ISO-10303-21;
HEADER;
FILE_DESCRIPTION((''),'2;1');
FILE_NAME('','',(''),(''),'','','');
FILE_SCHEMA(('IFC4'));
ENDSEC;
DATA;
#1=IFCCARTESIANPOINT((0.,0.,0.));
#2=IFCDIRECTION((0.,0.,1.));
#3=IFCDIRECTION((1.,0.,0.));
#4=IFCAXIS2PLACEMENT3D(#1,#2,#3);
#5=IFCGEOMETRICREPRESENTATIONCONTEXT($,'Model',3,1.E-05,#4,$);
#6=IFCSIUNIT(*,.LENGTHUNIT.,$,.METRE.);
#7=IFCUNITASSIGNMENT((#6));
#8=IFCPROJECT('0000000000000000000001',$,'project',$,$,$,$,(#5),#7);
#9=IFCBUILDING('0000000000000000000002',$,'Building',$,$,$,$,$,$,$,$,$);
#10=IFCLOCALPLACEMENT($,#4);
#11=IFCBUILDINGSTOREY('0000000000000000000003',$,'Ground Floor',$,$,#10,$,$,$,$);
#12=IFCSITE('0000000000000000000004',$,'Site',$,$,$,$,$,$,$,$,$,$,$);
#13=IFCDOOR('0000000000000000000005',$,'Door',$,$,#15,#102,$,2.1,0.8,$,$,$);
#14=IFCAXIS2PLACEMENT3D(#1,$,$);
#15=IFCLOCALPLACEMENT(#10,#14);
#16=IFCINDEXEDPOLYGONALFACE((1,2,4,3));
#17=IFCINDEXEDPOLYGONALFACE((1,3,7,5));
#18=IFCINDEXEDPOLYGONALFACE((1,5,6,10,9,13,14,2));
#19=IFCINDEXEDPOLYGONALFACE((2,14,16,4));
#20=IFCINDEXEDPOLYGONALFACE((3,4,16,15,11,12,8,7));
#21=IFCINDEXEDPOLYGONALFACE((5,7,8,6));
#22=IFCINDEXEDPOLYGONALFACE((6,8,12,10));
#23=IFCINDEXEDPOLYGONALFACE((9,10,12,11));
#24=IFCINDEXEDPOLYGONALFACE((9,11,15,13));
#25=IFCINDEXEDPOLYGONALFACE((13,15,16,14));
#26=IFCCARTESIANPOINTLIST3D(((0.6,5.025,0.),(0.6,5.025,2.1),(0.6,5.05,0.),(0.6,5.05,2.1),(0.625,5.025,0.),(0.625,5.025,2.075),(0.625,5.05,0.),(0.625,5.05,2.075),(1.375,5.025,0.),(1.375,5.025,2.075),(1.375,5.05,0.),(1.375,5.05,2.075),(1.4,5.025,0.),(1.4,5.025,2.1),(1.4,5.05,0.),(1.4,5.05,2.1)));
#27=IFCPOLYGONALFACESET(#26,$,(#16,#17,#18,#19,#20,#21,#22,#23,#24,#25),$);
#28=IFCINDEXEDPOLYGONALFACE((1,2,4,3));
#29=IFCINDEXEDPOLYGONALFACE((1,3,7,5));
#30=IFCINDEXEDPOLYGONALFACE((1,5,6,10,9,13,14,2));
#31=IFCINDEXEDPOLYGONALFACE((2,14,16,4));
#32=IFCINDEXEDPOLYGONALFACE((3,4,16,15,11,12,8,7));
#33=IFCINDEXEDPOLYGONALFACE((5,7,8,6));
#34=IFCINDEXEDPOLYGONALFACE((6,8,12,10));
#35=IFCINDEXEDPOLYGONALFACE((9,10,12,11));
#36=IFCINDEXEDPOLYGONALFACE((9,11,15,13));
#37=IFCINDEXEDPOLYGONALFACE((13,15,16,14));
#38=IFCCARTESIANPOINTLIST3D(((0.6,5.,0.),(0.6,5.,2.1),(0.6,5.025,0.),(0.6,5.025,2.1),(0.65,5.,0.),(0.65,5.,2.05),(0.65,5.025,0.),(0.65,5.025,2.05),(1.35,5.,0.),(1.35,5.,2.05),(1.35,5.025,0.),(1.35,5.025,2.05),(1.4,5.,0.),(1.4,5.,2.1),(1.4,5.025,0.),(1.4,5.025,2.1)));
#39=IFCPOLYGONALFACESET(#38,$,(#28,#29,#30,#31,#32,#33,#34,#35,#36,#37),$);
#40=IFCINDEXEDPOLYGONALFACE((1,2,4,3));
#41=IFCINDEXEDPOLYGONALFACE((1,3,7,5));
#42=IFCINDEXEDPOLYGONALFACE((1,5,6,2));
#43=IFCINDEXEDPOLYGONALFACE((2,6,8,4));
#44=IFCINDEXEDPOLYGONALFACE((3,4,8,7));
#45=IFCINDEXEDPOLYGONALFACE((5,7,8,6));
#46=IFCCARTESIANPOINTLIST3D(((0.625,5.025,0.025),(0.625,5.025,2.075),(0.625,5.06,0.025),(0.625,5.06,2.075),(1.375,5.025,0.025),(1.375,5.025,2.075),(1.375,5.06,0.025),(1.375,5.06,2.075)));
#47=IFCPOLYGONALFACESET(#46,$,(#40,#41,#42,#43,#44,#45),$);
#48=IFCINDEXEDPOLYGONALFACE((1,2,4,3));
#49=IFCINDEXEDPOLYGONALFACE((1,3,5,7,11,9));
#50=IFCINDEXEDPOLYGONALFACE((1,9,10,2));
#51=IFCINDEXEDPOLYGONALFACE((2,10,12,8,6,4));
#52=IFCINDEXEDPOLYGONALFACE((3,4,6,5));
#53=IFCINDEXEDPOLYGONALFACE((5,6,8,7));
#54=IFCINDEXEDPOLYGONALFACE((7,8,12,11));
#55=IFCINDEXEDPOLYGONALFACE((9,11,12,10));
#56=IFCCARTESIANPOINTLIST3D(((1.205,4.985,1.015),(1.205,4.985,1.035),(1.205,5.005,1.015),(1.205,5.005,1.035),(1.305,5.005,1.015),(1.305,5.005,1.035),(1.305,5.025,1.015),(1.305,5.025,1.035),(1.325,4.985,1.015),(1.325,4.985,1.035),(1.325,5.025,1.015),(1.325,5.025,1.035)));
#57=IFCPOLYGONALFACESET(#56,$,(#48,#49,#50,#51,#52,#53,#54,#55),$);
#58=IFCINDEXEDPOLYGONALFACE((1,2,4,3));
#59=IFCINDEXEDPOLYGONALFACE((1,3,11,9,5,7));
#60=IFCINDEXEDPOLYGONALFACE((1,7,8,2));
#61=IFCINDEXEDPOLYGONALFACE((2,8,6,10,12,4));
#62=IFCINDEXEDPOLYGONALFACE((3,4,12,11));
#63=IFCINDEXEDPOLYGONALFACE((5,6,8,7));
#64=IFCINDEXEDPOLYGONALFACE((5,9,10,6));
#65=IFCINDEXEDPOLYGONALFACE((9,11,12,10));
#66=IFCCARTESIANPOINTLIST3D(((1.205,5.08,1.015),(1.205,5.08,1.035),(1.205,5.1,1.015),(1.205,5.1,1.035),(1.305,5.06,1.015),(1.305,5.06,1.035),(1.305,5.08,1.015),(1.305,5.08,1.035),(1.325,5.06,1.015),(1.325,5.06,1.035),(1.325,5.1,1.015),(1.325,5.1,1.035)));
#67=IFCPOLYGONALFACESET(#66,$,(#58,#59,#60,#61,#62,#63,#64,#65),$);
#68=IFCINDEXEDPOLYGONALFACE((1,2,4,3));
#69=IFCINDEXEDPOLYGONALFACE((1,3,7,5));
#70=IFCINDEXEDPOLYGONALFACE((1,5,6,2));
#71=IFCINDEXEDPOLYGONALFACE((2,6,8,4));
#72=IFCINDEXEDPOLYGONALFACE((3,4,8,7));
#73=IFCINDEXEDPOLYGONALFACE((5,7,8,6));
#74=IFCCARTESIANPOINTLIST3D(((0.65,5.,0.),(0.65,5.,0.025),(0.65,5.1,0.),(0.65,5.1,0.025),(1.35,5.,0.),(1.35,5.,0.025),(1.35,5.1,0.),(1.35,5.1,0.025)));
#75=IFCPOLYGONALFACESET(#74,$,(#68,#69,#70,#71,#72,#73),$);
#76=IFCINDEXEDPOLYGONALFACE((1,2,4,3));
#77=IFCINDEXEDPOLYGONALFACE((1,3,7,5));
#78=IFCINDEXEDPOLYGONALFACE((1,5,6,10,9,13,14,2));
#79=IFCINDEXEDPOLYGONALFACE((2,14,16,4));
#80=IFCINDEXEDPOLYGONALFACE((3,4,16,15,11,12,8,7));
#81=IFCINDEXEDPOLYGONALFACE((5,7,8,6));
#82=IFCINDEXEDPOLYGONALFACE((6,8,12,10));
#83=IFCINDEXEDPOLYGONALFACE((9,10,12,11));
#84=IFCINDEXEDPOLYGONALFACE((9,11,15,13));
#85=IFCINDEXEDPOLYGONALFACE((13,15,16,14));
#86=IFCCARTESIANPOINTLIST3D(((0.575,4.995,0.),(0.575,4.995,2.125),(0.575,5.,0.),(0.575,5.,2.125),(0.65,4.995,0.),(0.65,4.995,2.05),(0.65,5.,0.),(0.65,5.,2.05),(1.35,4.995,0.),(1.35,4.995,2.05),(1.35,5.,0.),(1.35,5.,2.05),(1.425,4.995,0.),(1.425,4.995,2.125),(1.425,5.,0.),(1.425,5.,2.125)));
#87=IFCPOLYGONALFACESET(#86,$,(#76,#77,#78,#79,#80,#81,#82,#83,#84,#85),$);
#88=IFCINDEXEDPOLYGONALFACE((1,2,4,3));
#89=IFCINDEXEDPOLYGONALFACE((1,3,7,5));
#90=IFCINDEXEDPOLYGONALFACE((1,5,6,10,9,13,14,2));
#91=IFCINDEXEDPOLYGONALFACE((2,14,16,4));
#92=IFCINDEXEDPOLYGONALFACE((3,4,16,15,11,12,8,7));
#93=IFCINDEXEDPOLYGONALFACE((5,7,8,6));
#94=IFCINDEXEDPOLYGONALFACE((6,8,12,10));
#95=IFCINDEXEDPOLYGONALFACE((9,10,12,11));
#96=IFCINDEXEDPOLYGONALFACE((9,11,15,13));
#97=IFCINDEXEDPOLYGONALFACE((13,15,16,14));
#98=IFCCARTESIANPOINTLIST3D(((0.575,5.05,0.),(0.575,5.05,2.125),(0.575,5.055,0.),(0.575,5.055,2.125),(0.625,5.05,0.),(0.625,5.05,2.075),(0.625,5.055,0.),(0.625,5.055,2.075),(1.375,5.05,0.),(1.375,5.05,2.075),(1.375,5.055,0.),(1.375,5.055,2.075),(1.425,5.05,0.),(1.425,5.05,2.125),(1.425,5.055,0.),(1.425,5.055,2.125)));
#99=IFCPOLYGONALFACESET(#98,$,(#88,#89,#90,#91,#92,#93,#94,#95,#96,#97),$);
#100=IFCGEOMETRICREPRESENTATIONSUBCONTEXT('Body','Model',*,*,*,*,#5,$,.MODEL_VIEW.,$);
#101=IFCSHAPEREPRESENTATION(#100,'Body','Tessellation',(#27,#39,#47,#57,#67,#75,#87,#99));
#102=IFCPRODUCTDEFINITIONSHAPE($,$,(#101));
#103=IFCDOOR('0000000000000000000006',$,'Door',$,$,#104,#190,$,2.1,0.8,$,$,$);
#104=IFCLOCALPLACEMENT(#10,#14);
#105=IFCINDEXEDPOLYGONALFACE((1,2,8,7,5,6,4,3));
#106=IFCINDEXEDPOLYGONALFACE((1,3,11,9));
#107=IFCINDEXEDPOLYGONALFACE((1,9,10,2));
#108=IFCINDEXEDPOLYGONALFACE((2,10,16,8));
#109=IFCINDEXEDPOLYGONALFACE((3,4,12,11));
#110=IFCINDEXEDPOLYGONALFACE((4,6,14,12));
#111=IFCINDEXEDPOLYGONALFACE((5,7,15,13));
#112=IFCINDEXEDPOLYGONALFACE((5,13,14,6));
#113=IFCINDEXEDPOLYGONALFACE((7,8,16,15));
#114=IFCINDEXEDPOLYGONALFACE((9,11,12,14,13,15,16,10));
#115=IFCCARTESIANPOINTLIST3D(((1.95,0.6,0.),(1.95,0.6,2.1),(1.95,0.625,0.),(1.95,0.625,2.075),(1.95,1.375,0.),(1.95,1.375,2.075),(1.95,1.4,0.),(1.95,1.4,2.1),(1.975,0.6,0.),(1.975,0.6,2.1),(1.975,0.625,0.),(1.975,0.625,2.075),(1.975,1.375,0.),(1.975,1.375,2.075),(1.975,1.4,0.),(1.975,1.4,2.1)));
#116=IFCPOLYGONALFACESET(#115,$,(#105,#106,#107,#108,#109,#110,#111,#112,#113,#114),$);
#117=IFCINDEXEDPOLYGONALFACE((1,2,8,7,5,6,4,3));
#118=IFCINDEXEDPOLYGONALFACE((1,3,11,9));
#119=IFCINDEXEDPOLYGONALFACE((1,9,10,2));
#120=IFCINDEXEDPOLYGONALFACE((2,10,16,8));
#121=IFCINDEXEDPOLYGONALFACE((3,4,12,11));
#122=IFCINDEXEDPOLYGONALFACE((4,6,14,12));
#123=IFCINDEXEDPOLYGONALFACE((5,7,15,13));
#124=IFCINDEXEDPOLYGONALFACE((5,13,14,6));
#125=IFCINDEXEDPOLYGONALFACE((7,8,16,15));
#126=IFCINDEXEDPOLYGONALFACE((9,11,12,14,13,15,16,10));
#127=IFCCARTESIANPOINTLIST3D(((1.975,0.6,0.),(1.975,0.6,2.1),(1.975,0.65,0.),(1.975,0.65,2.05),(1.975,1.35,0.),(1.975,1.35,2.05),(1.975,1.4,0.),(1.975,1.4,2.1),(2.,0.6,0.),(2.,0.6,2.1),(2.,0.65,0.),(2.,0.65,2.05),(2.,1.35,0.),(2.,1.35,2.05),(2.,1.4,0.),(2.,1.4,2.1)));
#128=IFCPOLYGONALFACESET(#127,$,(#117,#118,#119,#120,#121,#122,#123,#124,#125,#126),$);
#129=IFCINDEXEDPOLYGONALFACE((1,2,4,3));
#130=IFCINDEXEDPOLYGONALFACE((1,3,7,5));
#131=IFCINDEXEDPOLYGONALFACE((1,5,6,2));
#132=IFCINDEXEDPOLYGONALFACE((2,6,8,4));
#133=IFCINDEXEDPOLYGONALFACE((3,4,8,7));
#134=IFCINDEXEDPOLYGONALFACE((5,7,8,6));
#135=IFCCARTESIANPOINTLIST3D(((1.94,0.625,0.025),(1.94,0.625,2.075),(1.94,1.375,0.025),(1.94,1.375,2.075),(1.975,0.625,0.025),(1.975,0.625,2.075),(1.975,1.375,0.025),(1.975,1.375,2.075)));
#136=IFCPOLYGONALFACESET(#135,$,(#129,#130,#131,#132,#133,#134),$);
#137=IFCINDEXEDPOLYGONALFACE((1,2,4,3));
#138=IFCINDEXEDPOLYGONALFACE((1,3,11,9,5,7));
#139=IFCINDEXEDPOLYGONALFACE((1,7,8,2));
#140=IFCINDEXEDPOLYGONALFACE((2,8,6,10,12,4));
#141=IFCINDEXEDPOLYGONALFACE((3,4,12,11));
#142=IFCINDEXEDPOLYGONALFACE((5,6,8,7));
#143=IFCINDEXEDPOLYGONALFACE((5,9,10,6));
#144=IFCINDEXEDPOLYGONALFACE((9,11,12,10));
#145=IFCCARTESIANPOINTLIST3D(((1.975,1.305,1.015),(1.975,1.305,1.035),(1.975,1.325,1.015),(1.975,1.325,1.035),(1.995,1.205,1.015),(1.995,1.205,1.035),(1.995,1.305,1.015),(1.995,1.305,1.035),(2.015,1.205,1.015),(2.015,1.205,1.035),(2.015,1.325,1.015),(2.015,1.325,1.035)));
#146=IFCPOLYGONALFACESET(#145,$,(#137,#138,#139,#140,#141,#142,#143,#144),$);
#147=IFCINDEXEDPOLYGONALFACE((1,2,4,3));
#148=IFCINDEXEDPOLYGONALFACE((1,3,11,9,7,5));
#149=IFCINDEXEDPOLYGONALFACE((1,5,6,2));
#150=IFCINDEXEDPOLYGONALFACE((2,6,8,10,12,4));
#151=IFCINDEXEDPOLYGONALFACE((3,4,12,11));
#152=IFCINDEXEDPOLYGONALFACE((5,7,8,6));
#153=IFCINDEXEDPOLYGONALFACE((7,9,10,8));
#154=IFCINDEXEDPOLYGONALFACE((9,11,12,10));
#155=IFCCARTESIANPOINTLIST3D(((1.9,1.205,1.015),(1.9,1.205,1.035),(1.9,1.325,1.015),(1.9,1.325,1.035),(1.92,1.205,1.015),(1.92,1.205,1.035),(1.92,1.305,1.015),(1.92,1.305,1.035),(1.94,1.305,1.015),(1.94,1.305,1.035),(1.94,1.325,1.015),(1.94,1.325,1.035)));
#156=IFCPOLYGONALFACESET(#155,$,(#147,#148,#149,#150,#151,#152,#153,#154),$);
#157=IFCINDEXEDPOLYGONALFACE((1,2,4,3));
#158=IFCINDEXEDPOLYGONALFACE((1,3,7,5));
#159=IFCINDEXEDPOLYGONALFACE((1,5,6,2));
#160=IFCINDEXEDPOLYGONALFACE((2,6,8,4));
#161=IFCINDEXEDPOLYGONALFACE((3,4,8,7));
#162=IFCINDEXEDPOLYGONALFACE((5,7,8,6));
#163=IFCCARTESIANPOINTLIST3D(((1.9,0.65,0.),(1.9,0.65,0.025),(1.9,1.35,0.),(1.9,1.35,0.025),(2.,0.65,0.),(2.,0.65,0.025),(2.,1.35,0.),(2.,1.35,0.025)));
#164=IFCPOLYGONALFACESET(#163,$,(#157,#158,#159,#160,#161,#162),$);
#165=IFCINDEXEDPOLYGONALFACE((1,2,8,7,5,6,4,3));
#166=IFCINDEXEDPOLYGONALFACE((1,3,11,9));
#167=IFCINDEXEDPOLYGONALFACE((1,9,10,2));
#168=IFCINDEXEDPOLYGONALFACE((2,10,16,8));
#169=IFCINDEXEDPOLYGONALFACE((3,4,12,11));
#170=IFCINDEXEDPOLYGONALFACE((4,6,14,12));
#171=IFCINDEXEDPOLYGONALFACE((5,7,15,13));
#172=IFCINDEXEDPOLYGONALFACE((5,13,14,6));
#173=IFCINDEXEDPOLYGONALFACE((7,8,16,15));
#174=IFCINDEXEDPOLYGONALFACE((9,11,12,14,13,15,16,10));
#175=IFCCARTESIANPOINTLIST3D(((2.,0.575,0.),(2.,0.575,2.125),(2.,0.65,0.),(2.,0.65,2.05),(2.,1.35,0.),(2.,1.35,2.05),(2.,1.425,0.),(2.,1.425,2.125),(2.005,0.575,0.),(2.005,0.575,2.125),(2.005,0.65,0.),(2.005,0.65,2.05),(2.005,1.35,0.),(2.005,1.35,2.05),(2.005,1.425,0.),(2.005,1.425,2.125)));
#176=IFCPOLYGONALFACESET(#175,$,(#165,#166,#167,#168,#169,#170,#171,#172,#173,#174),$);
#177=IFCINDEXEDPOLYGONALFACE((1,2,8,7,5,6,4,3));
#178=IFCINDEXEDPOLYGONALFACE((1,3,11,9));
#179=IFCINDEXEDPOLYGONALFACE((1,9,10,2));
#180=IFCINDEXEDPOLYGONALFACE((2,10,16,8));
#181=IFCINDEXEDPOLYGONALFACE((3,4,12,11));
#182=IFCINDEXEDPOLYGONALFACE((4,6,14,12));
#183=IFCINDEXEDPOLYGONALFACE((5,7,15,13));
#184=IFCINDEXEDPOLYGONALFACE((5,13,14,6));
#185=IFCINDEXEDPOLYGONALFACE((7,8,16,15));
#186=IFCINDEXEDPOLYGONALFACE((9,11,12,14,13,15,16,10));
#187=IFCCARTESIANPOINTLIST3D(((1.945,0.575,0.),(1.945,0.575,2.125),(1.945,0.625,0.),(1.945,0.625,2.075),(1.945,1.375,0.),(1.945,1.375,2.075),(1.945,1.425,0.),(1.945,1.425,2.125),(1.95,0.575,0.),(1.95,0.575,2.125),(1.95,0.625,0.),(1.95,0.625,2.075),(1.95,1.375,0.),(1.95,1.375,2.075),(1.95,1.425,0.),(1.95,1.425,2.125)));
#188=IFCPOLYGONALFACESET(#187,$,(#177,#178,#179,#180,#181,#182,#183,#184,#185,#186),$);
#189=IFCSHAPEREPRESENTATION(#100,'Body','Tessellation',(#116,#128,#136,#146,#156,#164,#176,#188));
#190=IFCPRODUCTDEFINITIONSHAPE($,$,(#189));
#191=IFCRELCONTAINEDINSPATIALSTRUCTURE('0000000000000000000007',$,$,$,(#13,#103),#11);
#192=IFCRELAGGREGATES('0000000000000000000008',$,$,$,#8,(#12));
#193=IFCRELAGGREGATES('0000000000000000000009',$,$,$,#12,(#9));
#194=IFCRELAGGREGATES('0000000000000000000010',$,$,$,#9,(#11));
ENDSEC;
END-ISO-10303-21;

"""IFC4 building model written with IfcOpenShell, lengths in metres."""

from ifc_helpers import new_model, si_unit, frame, origin_with_axes, place, context, subcontext, project, spatial, line, indexed_curve, outline, extrude, element, save


model = new_model("IFC4")

# Units and contexts
model_context = context("Model", 3, precision=1e-05, world=origin_with_axes())
body_context = subcontext(model_context, "Body", "Model", "MODEL_VIEW")
ifc_project = project(units=[si_unit("LENGTHUNIT", "METRE")], contexts=[model_context])

# Site, building, storey
site = spatial("IfcSite", under=ifc_project, Name="Site")
building = spatial("IfcBuilding", under=site, Name="Building")
storey_placement = place(None, origin_with_axes())
storey = spatial("IfcBuildingStorey", under=building, at=storey_placement, Name="Ground Floor")

# Doors
door_1_placement = place(storey_placement, frame((0.6, 5.0, 0.0), z_axis=(0.0, 0.0, 1.0), x_axis=(1.0, 0.0, 0.0)))
element("IfcDoor", 1, at=door_1_placement, inside=storey, Name="Door", OverallHeight=2.1, OverallWidth=0.8, context=body_context, shape_type="SweptSolid", body=[
    extrude(outline(indexed_curve([(0.0, 0.0), (0.0, 2.1), (0.8, 2.1), (0.8, 0.0), (0.775, 0.0), (0.775, 2.075), (0.025, 2.075), (0.025, 0.0)], segments=[line(1, 2, 3, 4, 5, 6, 7, 8, 1)])), frame((0.0, 0.025, 0.0), z_axis=(0.0, -1.0, 0.0), x_axis=(1.0, 0.0, 0.0)), (0.0, 0.0, -1.0), 0.025),
    extrude(outline(indexed_curve([(0.0, 0.0), (0.0, 2.1), (0.8, 2.1), (0.8, 0.0), (0.75, 0.0), (0.75, 2.05), (0.05, 2.05), (0.05, 0.0)], segments=[line(1, 2, 3, 4, 5, 6, 7, 8, 1)])), frame((0.0, 0.0, 0.0), z_axis=(0.0, -1.0, 0.0), x_axis=(1.0, 0.0, 0.0)), (0.0, 0.0, -1.0), 0.025),
    extrude(outline(indexed_curve([(0.0, 0.0), (0.75, 0.0), (0.75, 0.035), (0.0, 0.035)], segments=[line(1, 2, 3, 4, 1)])), frame((0.025, 0.025, 0.025), z_axis=(0.0, 0.0, 1.0), x_axis=(1.0, 0.0, 0.0)), (0.0, 0.0, 1.0), 2.05),
    extrude(outline(indexed_curve([(0.0, 0.0), (0.0, -0.04), (-0.12, -0.04), (-0.12, -0.02), (-0.02, -0.02), (-0.02, 0.0)], segments=[line(1, 2, 3, 4, 5, 6, 1)])), frame((0.725, 0.025, 1.015), z_axis=(0.0, 0.0, 1.0), x_axis=(1.0, 0.0, 0.0)), (0.0, 0.0, 1.0), 0.02),
    extrude(outline(indexed_curve([(0.0, 0.0), (0.0, 0.04), (-0.12, 0.04), (-0.12, 0.02), (-0.02, 0.02), (-0.02, 0.0)], segments=[line(1, 2, 3, 4, 5, 6, 1)])), frame((0.725, 0.06, 1.015), z_axis=(0.0, 0.0, 1.0), x_axis=(1.0, 0.0, 0.0)), (0.0, 0.0, 1.0), 0.02),
    extrude(outline(indexed_curve([(0.0, 0.0), (0.7, 0.0), (0.7, 0.1), (0.0, 0.1)], segments=[line(1, 2, 3, 4, 1)])), frame((0.05, 0.0, 0.0), z_axis=(0.0, 0.0, 1.0), x_axis=(1.0, 0.0, 0.0)), (0.0, 0.0, 1.0), 0.025),
    extrude(outline(indexed_curve([(0.0, 0.0), (0.0, 2.125), (0.85, 2.125), (0.85, 0.0), (0.775, 0.0), (0.775, 2.05), (0.075, 2.05), (0.075, 0.0)], segments=[line(1, 2, 3, 4, 5, 6, 7, 8, 1)])), frame((-0.025, -0.005, 0.0), z_axis=(0.0, -1.0, 0.0), x_axis=(1.0, 0.0, 0.0)), (0.0, 0.0, -1.0), 0.005),
    extrude(outline(indexed_curve([(0.0, 0.0), (0.0, 2.125), (0.85, 2.125), (0.85, 0.0), (0.8, 0.0), (0.8, 2.075), (0.05, 2.075), (0.05, 0.0)], segments=[line(1, 2, 3, 4, 5, 6, 7, 8, 1)])), frame((-0.025, 0.05, 0.0), z_axis=(0.0, -1.0, 0.0), x_axis=(1.0, 0.0, 0.0)), (0.0, 0.0, -1.0), 0.005),
])
door_2_placement = place(storey_placement, frame((2.0, 0.6, 0.0), z_axis=(0.0, 0.0, 1.0), x_axis=(0.0, 1.0, 0.0)))
element("IfcDoor", 2, at=door_2_placement, inside=storey, Name="Door", OverallHeight=2.1, OverallWidth=0.8, context=body_context, shape_type="SweptSolid", body=[
    extrude(outline(indexed_curve([(0.0, 0.0), (0.0, 2.1), (0.8, 2.1), (0.8, 0.0), (0.775, 0.0), (0.775, 2.075), (0.025, 2.075), (0.025, 0.0)], segments=[line(1, 2, 3, 4, 5, 6, 7, 8, 1)])), frame((0.0, 0.025, 0.0), z_axis=(0.0, -1.0, 0.0), x_axis=(1.0, 0.0, 0.0)), (0.0, 0.0, -1.0), 0.025),
    extrude(outline(indexed_curve([(0.0, 0.0), (0.0, 2.1), (0.8, 2.1), (0.8, 0.0), (0.75, 0.0), (0.75, 2.05), (0.05, 2.05), (0.05, 0.0)], segments=[line(1, 2, 3, 4, 5, 6, 7, 8, 1)])), frame((0.0, 0.0, 0.0), z_axis=(0.0, -1.0, 0.0), x_axis=(1.0, 0.0, 0.0)), (0.0, 0.0, -1.0), 0.025),
    extrude(outline(indexed_curve([(0.0, 0.0), (0.75, 0.0), (0.75, 0.035), (0.0, 0.035)], segments=[line(1, 2, 3, 4, 1)])), frame((0.025, 0.025, 0.025), z_axis=(0.0, 0.0, 1.0), x_axis=(1.0, 0.0, 0.0)), (0.0, 0.0, 1.0), 2.05),
    extrude(outline(indexed_curve([(0.0, 0.0), (0.0, -0.04), (-0.12, -0.04), (-0.12, -0.02), (-0.02, -0.02), (-0.02, 0.0)], segments=[line(1, 2, 3, 4, 5, 6, 1)])), frame((0.725, 0.025, 1.015), z_axis=(0.0, 0.0, 1.0), x_axis=(1.0, 0.0, 0.0)), (0.0, 0.0, 1.0), 0.02),
    extrude(outline(indexed_curve([(0.0, 0.0), (0.0, 0.04), (-0.12, 0.04), (-0.12, 0.02), (-0.02, 0.02), (-0.02, 0.0)], segments=[line(1, 2, 3, 4, 5, 6, 1)])), frame((0.725, 0.06, 1.015), z_axis=(0.0, 0.0, 1.0), x_axis=(1.0, 0.0, 0.0)), (0.0, 0.0, 1.0), 0.02),
    extrude(outline(indexed_curve([(0.0, 0.0), (0.7, 0.0), (0.7, 0.1), (0.0, 0.1)], segments=[line(1, 2, 3, 4, 1)])), frame((0.05, 0.0, 0.0), z_axis=(0.0, 0.0, 1.0), x_axis=(1.0, 0.0, 0.0)), (0.0, 0.0, 1.0), 0.025),
    extrude(outline(indexed_curve([(0.0, 0.0), (0.0, 2.125), (0.85, 2.125), (0.85, 0.0), (0.775, 0.0), (0.775, 2.05), (0.075, 2.05), (0.075, 0.0)], segments=[line(1, 2, 3, 4, 5, 6, 7, 8, 1)])), frame((-0.025, -0.005, 0.0), z_axis=(0.0, -1.0, 0.0), x_axis=(1.0, 0.0, 0.0)), (0.0, 0.0, -1.0), 0.005),
    extrude(outline(indexed_curve([(0.0, 0.0), (0.0, 2.125), (0.85, 2.125), (0.85, 0.0), (0.8, 0.0), (0.8, 2.075), (0.05, 2.075), (0.05, 0.0)], segments=[line(1, 2, 3, 4, 5, 6, 7, 8, 1)])), frame((-0.025, 0.05, 0.0), z_axis=(0.0, -1.0, 0.0), x_axis=(1.0, 0.0, 0.0)), (0.0, 0.0, -1.0), 0.005),
])

save(model, "model.ifc")
